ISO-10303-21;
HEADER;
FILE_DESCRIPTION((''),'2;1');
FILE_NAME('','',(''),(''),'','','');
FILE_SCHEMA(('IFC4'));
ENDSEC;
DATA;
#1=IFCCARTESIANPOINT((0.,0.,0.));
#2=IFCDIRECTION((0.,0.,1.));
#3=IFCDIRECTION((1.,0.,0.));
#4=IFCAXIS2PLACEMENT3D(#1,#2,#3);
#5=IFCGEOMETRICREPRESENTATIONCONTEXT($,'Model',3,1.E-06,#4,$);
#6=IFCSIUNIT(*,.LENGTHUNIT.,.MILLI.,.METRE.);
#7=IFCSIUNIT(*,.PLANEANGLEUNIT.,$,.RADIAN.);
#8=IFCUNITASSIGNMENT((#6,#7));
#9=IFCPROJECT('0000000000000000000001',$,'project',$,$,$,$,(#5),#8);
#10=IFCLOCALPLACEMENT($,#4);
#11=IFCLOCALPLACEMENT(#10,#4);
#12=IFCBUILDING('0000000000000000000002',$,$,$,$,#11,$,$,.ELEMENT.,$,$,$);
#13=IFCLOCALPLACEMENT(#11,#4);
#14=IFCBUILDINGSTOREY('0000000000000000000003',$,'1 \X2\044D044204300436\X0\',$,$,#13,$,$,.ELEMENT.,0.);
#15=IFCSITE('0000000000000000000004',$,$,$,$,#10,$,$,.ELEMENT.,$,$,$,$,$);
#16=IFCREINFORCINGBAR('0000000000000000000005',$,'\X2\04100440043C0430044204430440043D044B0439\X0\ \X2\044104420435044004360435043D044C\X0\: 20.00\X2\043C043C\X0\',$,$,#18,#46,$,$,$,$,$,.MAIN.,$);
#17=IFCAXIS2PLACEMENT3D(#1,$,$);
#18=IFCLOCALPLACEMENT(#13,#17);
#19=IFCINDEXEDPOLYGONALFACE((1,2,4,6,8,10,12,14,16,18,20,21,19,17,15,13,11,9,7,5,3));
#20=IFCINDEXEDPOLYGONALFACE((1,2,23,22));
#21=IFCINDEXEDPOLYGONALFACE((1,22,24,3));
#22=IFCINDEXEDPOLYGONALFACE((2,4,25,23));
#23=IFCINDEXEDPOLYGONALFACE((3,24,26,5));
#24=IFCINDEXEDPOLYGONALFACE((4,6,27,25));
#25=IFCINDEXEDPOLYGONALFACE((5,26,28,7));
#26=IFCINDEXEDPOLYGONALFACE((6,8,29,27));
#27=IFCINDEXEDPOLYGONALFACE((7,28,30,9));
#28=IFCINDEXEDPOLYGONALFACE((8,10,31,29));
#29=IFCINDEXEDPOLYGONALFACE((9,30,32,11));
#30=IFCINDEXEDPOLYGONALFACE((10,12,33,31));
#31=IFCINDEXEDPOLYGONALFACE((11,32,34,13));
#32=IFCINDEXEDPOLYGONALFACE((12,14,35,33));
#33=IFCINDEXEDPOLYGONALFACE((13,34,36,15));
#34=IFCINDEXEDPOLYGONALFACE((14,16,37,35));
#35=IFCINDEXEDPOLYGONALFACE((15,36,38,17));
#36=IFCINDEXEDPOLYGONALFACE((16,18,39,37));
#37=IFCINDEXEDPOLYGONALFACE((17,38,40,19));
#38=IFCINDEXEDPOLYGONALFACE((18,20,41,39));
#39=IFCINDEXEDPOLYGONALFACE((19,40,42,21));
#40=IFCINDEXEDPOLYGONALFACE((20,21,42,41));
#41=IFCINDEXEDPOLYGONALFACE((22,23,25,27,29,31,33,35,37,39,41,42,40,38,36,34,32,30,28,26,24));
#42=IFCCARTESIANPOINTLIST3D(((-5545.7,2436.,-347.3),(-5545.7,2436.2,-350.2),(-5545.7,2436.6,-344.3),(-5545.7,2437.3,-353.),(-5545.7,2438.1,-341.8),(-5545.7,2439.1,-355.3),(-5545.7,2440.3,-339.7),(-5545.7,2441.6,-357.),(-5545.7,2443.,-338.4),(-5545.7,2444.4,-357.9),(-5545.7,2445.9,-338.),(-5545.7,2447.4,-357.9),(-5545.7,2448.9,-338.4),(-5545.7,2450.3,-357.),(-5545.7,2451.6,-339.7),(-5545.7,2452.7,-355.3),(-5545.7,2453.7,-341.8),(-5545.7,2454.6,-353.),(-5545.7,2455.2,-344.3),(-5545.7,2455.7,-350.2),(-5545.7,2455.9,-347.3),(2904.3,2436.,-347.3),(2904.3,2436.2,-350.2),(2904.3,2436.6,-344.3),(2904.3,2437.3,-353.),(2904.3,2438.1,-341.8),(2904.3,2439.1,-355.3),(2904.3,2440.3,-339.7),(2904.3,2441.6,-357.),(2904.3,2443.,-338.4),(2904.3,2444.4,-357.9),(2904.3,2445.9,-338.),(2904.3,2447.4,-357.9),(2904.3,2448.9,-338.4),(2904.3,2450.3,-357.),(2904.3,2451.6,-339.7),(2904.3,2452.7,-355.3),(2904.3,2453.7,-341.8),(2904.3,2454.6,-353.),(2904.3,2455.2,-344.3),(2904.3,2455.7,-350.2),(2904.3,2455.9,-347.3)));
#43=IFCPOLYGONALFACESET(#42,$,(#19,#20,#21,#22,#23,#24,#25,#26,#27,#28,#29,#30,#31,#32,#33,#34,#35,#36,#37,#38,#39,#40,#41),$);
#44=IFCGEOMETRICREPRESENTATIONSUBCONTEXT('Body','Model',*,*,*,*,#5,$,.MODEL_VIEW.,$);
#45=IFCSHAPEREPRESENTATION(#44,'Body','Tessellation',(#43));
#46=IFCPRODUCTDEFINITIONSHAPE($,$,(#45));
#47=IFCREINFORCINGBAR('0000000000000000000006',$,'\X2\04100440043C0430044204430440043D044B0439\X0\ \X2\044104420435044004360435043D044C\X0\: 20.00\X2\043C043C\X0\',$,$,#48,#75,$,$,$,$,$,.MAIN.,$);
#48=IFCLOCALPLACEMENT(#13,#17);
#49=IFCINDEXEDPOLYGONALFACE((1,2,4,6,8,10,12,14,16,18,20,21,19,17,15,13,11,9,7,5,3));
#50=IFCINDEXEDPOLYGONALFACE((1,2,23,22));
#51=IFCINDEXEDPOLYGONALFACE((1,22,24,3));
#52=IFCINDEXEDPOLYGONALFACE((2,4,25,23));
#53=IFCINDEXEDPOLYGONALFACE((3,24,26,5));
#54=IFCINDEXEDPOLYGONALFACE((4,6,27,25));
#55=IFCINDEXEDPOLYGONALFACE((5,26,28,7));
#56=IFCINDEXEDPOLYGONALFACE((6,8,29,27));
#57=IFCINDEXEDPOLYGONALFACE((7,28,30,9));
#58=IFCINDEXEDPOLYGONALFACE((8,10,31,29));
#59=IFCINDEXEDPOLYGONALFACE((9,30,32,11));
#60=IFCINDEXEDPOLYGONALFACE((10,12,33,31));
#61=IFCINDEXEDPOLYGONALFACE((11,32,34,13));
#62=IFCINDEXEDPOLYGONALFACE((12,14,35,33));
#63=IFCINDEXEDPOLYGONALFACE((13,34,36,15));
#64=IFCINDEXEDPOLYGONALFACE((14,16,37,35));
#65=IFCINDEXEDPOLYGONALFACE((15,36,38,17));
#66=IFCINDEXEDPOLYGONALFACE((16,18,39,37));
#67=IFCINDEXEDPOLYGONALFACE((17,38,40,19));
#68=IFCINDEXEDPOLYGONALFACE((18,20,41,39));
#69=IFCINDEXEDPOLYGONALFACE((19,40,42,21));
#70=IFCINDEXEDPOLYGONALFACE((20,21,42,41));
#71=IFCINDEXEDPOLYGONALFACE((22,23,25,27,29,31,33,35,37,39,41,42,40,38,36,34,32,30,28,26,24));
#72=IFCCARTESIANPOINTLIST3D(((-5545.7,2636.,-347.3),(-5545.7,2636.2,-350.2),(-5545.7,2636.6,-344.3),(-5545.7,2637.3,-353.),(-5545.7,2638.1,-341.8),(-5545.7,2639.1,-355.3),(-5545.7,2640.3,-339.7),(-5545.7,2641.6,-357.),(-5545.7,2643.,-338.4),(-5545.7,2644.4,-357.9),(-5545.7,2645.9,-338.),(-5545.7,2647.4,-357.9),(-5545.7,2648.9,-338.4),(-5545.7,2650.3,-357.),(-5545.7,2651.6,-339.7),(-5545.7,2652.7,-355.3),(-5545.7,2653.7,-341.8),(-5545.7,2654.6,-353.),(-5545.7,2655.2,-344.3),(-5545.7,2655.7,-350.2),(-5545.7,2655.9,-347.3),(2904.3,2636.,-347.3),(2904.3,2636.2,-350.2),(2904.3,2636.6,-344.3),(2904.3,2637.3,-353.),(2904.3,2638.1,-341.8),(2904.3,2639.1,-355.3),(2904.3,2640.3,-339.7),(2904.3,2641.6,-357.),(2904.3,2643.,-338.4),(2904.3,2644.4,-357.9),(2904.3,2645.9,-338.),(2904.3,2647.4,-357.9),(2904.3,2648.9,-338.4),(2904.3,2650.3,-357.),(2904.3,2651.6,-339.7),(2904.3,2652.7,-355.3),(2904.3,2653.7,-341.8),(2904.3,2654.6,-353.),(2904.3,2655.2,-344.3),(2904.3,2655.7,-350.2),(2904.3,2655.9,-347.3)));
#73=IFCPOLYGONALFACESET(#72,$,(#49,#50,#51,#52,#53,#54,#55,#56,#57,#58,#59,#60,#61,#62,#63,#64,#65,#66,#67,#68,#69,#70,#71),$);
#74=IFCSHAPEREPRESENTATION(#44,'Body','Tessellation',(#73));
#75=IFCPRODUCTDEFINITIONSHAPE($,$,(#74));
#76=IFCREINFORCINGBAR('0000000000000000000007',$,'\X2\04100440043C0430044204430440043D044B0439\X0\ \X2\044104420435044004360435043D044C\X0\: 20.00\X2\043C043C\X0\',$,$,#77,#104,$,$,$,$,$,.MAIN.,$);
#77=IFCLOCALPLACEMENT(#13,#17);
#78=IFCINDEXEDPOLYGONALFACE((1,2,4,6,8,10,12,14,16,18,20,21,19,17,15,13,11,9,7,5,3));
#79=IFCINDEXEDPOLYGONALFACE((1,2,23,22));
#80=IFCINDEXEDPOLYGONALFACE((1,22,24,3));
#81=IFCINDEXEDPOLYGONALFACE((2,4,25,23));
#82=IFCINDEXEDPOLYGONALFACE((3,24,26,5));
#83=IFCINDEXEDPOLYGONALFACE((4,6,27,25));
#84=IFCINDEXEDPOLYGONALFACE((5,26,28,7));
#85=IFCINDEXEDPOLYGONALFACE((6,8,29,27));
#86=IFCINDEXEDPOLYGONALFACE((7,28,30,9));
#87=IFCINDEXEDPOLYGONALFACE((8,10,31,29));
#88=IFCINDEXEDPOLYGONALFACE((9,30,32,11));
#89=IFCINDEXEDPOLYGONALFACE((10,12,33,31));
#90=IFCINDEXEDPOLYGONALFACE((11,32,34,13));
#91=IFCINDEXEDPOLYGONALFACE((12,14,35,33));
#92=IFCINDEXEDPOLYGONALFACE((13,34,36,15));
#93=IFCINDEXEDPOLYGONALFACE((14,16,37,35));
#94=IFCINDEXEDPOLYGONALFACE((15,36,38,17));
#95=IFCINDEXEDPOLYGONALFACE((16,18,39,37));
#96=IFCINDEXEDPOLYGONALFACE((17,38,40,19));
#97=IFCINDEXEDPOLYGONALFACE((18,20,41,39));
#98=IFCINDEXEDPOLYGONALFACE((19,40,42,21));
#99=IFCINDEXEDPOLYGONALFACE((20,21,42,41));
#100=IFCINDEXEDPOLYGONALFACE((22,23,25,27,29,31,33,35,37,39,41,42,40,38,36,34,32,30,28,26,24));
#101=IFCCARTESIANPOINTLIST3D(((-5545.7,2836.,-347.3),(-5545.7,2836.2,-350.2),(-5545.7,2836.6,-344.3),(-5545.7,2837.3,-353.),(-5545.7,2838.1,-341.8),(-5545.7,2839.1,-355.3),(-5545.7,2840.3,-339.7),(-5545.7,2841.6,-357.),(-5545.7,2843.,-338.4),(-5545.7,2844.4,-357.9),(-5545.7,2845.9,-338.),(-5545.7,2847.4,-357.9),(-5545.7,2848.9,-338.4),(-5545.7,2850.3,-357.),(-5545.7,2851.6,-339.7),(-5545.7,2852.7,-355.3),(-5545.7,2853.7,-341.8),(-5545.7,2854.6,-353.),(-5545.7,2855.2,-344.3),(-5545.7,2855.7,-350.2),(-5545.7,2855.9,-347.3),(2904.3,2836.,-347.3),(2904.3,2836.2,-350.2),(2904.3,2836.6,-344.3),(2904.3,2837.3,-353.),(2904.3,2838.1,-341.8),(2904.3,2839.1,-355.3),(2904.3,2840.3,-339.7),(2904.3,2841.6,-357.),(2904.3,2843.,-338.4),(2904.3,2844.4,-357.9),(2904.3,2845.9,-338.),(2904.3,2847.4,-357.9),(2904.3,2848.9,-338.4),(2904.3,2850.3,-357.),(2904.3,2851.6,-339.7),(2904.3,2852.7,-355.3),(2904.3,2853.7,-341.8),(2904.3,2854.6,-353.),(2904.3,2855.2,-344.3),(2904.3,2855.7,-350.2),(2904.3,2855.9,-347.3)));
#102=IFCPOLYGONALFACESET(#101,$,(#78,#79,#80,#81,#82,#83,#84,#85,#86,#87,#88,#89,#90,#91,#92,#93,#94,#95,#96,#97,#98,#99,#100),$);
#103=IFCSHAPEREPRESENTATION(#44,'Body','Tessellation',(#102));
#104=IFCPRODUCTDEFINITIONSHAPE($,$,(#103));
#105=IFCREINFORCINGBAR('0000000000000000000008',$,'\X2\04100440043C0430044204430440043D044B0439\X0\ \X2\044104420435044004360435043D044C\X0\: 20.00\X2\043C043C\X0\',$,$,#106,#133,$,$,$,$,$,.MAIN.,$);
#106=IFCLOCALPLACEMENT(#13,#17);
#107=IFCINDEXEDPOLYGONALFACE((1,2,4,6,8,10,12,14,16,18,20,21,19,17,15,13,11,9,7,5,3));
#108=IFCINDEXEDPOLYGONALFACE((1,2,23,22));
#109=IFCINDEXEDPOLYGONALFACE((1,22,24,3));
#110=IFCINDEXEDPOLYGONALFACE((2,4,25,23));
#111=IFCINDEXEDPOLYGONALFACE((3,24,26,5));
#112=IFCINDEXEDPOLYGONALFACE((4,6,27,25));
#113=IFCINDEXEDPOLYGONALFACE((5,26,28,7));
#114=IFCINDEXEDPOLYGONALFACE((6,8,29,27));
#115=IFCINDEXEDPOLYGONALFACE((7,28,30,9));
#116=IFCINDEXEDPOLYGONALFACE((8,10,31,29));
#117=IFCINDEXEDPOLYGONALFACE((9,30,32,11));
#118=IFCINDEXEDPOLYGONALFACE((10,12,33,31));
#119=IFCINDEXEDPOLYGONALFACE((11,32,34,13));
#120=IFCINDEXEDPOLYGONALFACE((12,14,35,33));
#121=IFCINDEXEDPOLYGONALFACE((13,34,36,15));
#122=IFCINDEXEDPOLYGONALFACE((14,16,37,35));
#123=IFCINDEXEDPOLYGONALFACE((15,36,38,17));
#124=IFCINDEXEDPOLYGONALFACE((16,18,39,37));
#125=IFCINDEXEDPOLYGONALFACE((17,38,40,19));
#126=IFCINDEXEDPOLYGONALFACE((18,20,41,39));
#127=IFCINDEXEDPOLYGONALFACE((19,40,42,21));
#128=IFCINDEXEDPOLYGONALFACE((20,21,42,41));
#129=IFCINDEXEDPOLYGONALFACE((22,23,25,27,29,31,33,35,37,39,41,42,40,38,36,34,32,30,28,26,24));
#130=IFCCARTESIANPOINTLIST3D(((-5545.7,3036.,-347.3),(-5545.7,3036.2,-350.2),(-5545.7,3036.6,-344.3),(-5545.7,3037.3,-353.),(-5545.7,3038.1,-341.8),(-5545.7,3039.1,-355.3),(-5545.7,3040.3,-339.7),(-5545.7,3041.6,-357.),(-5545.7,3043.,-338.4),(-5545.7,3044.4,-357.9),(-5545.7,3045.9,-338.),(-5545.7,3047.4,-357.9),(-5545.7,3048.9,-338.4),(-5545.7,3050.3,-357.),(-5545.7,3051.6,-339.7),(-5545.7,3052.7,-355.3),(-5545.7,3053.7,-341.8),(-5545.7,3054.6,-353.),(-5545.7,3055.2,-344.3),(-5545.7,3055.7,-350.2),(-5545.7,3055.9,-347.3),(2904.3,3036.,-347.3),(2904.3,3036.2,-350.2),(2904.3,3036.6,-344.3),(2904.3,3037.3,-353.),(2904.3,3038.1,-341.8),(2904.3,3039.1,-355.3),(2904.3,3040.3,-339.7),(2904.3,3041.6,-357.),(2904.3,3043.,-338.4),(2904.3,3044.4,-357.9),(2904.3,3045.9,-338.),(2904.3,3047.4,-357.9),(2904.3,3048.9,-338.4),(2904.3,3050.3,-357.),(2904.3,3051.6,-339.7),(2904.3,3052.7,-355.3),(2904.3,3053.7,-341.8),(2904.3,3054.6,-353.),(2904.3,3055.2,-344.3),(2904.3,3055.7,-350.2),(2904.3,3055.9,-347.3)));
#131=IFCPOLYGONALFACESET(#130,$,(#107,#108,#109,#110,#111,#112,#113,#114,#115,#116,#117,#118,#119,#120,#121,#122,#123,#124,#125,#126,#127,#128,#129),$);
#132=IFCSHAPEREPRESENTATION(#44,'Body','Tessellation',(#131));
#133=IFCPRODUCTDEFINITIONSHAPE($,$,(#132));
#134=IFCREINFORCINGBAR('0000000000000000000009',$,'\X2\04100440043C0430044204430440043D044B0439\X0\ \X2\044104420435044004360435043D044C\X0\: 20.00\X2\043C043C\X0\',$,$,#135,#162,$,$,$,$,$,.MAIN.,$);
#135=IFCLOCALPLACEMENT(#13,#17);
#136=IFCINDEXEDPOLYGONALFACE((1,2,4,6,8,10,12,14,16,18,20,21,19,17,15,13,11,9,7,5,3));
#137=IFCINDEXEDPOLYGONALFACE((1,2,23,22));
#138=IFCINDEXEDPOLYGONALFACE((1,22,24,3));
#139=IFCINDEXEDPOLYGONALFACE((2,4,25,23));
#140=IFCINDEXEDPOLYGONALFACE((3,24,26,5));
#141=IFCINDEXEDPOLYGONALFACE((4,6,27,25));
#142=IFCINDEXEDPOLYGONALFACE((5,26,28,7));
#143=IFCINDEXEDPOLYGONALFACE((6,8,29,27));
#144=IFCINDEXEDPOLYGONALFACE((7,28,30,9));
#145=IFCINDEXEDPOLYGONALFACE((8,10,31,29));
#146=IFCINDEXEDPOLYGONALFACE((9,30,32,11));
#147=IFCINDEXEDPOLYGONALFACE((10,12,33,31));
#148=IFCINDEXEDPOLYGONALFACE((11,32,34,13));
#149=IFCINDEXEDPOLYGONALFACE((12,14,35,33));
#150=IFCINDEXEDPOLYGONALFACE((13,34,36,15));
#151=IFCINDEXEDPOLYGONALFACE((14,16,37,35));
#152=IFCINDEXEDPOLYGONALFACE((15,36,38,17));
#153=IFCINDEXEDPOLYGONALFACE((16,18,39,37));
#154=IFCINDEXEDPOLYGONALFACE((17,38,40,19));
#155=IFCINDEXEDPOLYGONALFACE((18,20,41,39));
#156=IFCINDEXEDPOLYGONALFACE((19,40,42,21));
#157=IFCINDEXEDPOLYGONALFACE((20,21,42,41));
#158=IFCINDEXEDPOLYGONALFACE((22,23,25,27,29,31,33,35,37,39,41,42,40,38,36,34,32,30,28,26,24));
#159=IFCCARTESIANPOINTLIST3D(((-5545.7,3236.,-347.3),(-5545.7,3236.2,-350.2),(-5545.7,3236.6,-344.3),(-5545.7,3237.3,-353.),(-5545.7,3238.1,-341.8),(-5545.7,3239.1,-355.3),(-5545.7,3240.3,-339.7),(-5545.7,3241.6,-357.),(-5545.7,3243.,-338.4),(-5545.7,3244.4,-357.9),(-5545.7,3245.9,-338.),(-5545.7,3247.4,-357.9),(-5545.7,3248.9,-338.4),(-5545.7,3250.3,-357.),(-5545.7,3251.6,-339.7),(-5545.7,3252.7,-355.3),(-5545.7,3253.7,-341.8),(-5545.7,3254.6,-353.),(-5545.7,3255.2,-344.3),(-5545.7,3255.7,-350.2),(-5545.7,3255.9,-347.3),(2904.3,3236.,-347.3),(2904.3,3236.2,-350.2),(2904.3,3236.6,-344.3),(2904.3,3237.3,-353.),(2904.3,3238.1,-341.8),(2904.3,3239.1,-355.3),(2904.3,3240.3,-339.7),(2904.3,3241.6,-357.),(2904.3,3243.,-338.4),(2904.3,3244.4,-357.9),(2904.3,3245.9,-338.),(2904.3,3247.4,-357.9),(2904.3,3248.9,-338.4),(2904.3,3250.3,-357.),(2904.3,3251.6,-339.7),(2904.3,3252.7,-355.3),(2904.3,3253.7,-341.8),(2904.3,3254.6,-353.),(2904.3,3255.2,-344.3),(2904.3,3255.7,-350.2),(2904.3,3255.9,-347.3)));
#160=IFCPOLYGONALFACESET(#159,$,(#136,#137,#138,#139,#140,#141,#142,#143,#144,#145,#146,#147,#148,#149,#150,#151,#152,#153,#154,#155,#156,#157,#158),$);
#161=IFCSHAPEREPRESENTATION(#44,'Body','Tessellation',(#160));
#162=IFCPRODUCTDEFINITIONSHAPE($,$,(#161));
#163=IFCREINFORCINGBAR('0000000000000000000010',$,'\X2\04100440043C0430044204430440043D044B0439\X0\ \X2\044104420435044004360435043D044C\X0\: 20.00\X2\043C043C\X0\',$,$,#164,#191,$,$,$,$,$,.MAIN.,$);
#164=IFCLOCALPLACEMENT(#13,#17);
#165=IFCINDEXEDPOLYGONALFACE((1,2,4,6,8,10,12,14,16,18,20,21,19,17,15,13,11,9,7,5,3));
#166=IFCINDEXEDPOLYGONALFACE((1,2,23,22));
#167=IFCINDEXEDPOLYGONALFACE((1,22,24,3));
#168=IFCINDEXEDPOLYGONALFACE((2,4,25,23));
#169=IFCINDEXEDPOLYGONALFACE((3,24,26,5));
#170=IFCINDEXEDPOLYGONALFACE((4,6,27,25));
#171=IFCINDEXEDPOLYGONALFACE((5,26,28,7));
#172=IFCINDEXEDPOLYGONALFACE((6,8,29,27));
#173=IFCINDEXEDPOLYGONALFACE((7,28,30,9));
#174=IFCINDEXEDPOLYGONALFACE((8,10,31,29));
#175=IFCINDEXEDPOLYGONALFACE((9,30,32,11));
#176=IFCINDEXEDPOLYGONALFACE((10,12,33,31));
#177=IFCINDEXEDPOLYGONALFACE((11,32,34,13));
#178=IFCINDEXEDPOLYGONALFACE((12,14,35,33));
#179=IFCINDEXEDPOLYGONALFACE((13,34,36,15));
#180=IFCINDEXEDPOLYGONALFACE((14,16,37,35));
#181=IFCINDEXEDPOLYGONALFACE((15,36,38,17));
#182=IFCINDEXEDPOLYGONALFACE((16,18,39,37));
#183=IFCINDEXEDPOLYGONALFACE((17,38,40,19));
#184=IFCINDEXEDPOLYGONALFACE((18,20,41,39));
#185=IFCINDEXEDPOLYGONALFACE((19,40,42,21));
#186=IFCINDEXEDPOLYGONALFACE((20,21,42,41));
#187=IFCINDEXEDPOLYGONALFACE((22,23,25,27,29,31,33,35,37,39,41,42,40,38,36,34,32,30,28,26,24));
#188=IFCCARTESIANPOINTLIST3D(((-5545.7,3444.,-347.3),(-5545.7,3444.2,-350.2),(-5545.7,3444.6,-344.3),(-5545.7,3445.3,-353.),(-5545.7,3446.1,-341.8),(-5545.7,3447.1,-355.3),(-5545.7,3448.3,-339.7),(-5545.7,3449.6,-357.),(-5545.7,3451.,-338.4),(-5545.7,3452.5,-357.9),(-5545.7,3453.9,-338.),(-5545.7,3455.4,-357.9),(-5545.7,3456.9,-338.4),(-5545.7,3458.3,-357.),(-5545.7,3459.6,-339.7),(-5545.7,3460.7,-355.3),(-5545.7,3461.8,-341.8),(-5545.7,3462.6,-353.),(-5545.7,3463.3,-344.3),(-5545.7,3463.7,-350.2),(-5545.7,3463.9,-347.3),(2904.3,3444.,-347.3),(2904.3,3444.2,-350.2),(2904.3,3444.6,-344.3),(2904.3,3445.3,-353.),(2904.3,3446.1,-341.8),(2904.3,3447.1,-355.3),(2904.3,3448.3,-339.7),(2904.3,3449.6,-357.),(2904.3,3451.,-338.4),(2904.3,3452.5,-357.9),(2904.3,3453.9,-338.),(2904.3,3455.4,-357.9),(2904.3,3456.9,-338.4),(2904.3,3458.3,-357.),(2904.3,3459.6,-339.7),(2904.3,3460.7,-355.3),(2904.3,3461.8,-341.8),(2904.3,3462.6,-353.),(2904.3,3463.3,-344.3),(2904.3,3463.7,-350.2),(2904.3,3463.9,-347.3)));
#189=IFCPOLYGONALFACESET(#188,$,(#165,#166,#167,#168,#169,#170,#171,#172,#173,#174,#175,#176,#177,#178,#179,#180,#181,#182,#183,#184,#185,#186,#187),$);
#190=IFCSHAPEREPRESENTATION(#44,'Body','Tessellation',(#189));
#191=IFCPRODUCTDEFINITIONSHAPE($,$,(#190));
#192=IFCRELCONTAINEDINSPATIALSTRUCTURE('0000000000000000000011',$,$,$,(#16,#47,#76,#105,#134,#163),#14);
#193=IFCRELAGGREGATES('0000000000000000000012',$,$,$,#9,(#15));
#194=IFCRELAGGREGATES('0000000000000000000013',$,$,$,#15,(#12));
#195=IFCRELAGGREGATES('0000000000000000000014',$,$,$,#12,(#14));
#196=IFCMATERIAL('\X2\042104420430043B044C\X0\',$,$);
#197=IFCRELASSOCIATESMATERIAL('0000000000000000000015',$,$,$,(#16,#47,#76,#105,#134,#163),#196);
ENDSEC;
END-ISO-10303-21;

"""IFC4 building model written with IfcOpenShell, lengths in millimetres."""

from ifc_helpers import new_model, entity, si_unit, origin_with_axes, place, context, subcontext, project, spatial, source, transform, mapped, material, element, save


model = new_model("IFC4")

# Units and contexts
model_context = context("Model", 3, precision=1e-06, world=origin_with_axes())
body_context = subcontext(model_context, "Body", "Model", "MODEL_VIEW")
ifc_project = project(units=[si_unit("LENGTHUNIT", "METRE", prefix="MILLI"), si_unit("PLANEANGLEUNIT", "RADIAN")], contexts=[model_context])

# Site, building, storey
site_placement = place(None, origin_with_axes())
site = spatial("IfcSite", under=ifc_project, at=site_placement, CompositionType="ELEMENT")
building_placement = place(site_placement, origin_with_axes())
building = spatial("IfcBuilding", under=site, at=building_placement, CompositionType="ELEMENT")
storey_placement = place(building_placement, origin_with_axes())
storey = spatial("IfcBuildingStorey", under=building, at=storey_placement, Name="1 этаж", CompositionType="ELEMENT", Elevation=0.0)

# Reinforcing bars
ifc_material = material(Name="Сталь")
shared_shape_1 = source(origin_with_axes(), body_context, "Body", "AdvancedSweptSolid", [
    entity("IfcSweptDiskSolid", entity("IfcIndexedPolyCurve", entity("IfcCartesianPointList3D", [[0.0, 0.0, 0.0], [8450.0, 0.0, 0.0]]), [entity("IfcLineIndex", [1, 2])]), 10.0),
])
reinforcing_bar_1_placement = place(storey_placement, origin_with_axes())
element("IfcReinforcingBar", 1, at=reinforcing_bar_1_placement, inside=storey, material=ifc_material, Name="Арматурный стержень: 20.00мм", PredefinedType="MAIN", context=body_context, shape_type="MappedRepresentation", body=[
    mapped(shared_shape_1, transform((-5545.7, 2445.9, -348.0), x_axis=(1.0, 0.0, 0.0), y_axis=(0.0, 1.0, 0.0), z_axis=(0.0, 0.0, 1.0), scale=1.0)),
])
reinforcing_bar_2_placement = place(storey_placement, origin_with_axes())
element("IfcReinforcingBar", 2, at=reinforcing_bar_2_placement, inside=storey, material=ifc_material, Name="Арматурный стержень: 20.00мм", PredefinedType="MAIN", context=body_context, shape_type="MappedRepresentation", body=[
    mapped(shared_shape_1, transform((-5545.7, 2645.9, -348.0), x_axis=(1.0, 0.0, 0.0), y_axis=(0.0, 1.0, 0.0), z_axis=(0.0, 0.0, 1.0), scale=1.0)),
])
reinforcing_bar_3_placement = place(storey_placement, origin_with_axes())
element("IfcReinforcingBar", 3, at=reinforcing_bar_3_placement, inside=storey, material=ifc_material, Name="Арматурный стержень: 20.00мм", PredefinedType="MAIN", context=body_context, shape_type="MappedRepresentation", body=[
    mapped(shared_shape_1, transform((-5545.7, 2845.9, -348.0), x_axis=(1.0, 0.0, 0.0), y_axis=(0.0, 1.0, 0.0), z_axis=(0.0, 0.0, 1.0), scale=1.0)),
])
reinforcing_bar_4_placement = place(storey_placement, origin_with_axes())
element("IfcReinforcingBar", 4, at=reinforcing_bar_4_placement, inside=storey, material=ifc_material, Name="Арматурный стержень: 20.00мм", PredefinedType="MAIN", context=body_context, shape_type="MappedRepresentation", body=[
    mapped(shared_shape_1, transform((-5545.7, 3045.9, -348.0), x_axis=(1.0, 0.0, 0.0), y_axis=(0.0, 1.0, 0.0), z_axis=(0.0, 0.0, 1.0), scale=1.0)),
])
reinforcing_bar_5_placement = place(storey_placement, origin_with_axes())
element("IfcReinforcingBar", 5, at=reinforcing_bar_5_placement, inside=storey, material=ifc_material, Name="Арматурный стержень: 20.00мм", PredefinedType="MAIN", context=body_context, shape_type="MappedRepresentation", body=[
    mapped(shared_shape_1, transform((-5545.7, 3245.9, -348.0), x_axis=(1.0, 0.0, 0.0), y_axis=(0.0, 1.0, 0.0), z_axis=(0.0, 0.0, 1.0), scale=1.0)),
])
reinforcing_bar_6_placement = place(storey_placement, origin_with_axes())
element("IfcReinforcingBar", 6, at=reinforcing_bar_6_placement, inside=storey, material=ifc_material, Name="Арматурный стержень: 20.00мм", PredefinedType="MAIN", context=body_context, shape_type="MappedRepresentation", body=[
    mapped(shared_shape_1, transform((-5545.7, 3453.9, -348.0), x_axis=(1.0, 0.0, 0.0), y_axis=(0.0, 1.0, 0.0), z_axis=(0.0, 0.0, 1.0), scale=1.0)),
])

save(model, "model.ifc")
